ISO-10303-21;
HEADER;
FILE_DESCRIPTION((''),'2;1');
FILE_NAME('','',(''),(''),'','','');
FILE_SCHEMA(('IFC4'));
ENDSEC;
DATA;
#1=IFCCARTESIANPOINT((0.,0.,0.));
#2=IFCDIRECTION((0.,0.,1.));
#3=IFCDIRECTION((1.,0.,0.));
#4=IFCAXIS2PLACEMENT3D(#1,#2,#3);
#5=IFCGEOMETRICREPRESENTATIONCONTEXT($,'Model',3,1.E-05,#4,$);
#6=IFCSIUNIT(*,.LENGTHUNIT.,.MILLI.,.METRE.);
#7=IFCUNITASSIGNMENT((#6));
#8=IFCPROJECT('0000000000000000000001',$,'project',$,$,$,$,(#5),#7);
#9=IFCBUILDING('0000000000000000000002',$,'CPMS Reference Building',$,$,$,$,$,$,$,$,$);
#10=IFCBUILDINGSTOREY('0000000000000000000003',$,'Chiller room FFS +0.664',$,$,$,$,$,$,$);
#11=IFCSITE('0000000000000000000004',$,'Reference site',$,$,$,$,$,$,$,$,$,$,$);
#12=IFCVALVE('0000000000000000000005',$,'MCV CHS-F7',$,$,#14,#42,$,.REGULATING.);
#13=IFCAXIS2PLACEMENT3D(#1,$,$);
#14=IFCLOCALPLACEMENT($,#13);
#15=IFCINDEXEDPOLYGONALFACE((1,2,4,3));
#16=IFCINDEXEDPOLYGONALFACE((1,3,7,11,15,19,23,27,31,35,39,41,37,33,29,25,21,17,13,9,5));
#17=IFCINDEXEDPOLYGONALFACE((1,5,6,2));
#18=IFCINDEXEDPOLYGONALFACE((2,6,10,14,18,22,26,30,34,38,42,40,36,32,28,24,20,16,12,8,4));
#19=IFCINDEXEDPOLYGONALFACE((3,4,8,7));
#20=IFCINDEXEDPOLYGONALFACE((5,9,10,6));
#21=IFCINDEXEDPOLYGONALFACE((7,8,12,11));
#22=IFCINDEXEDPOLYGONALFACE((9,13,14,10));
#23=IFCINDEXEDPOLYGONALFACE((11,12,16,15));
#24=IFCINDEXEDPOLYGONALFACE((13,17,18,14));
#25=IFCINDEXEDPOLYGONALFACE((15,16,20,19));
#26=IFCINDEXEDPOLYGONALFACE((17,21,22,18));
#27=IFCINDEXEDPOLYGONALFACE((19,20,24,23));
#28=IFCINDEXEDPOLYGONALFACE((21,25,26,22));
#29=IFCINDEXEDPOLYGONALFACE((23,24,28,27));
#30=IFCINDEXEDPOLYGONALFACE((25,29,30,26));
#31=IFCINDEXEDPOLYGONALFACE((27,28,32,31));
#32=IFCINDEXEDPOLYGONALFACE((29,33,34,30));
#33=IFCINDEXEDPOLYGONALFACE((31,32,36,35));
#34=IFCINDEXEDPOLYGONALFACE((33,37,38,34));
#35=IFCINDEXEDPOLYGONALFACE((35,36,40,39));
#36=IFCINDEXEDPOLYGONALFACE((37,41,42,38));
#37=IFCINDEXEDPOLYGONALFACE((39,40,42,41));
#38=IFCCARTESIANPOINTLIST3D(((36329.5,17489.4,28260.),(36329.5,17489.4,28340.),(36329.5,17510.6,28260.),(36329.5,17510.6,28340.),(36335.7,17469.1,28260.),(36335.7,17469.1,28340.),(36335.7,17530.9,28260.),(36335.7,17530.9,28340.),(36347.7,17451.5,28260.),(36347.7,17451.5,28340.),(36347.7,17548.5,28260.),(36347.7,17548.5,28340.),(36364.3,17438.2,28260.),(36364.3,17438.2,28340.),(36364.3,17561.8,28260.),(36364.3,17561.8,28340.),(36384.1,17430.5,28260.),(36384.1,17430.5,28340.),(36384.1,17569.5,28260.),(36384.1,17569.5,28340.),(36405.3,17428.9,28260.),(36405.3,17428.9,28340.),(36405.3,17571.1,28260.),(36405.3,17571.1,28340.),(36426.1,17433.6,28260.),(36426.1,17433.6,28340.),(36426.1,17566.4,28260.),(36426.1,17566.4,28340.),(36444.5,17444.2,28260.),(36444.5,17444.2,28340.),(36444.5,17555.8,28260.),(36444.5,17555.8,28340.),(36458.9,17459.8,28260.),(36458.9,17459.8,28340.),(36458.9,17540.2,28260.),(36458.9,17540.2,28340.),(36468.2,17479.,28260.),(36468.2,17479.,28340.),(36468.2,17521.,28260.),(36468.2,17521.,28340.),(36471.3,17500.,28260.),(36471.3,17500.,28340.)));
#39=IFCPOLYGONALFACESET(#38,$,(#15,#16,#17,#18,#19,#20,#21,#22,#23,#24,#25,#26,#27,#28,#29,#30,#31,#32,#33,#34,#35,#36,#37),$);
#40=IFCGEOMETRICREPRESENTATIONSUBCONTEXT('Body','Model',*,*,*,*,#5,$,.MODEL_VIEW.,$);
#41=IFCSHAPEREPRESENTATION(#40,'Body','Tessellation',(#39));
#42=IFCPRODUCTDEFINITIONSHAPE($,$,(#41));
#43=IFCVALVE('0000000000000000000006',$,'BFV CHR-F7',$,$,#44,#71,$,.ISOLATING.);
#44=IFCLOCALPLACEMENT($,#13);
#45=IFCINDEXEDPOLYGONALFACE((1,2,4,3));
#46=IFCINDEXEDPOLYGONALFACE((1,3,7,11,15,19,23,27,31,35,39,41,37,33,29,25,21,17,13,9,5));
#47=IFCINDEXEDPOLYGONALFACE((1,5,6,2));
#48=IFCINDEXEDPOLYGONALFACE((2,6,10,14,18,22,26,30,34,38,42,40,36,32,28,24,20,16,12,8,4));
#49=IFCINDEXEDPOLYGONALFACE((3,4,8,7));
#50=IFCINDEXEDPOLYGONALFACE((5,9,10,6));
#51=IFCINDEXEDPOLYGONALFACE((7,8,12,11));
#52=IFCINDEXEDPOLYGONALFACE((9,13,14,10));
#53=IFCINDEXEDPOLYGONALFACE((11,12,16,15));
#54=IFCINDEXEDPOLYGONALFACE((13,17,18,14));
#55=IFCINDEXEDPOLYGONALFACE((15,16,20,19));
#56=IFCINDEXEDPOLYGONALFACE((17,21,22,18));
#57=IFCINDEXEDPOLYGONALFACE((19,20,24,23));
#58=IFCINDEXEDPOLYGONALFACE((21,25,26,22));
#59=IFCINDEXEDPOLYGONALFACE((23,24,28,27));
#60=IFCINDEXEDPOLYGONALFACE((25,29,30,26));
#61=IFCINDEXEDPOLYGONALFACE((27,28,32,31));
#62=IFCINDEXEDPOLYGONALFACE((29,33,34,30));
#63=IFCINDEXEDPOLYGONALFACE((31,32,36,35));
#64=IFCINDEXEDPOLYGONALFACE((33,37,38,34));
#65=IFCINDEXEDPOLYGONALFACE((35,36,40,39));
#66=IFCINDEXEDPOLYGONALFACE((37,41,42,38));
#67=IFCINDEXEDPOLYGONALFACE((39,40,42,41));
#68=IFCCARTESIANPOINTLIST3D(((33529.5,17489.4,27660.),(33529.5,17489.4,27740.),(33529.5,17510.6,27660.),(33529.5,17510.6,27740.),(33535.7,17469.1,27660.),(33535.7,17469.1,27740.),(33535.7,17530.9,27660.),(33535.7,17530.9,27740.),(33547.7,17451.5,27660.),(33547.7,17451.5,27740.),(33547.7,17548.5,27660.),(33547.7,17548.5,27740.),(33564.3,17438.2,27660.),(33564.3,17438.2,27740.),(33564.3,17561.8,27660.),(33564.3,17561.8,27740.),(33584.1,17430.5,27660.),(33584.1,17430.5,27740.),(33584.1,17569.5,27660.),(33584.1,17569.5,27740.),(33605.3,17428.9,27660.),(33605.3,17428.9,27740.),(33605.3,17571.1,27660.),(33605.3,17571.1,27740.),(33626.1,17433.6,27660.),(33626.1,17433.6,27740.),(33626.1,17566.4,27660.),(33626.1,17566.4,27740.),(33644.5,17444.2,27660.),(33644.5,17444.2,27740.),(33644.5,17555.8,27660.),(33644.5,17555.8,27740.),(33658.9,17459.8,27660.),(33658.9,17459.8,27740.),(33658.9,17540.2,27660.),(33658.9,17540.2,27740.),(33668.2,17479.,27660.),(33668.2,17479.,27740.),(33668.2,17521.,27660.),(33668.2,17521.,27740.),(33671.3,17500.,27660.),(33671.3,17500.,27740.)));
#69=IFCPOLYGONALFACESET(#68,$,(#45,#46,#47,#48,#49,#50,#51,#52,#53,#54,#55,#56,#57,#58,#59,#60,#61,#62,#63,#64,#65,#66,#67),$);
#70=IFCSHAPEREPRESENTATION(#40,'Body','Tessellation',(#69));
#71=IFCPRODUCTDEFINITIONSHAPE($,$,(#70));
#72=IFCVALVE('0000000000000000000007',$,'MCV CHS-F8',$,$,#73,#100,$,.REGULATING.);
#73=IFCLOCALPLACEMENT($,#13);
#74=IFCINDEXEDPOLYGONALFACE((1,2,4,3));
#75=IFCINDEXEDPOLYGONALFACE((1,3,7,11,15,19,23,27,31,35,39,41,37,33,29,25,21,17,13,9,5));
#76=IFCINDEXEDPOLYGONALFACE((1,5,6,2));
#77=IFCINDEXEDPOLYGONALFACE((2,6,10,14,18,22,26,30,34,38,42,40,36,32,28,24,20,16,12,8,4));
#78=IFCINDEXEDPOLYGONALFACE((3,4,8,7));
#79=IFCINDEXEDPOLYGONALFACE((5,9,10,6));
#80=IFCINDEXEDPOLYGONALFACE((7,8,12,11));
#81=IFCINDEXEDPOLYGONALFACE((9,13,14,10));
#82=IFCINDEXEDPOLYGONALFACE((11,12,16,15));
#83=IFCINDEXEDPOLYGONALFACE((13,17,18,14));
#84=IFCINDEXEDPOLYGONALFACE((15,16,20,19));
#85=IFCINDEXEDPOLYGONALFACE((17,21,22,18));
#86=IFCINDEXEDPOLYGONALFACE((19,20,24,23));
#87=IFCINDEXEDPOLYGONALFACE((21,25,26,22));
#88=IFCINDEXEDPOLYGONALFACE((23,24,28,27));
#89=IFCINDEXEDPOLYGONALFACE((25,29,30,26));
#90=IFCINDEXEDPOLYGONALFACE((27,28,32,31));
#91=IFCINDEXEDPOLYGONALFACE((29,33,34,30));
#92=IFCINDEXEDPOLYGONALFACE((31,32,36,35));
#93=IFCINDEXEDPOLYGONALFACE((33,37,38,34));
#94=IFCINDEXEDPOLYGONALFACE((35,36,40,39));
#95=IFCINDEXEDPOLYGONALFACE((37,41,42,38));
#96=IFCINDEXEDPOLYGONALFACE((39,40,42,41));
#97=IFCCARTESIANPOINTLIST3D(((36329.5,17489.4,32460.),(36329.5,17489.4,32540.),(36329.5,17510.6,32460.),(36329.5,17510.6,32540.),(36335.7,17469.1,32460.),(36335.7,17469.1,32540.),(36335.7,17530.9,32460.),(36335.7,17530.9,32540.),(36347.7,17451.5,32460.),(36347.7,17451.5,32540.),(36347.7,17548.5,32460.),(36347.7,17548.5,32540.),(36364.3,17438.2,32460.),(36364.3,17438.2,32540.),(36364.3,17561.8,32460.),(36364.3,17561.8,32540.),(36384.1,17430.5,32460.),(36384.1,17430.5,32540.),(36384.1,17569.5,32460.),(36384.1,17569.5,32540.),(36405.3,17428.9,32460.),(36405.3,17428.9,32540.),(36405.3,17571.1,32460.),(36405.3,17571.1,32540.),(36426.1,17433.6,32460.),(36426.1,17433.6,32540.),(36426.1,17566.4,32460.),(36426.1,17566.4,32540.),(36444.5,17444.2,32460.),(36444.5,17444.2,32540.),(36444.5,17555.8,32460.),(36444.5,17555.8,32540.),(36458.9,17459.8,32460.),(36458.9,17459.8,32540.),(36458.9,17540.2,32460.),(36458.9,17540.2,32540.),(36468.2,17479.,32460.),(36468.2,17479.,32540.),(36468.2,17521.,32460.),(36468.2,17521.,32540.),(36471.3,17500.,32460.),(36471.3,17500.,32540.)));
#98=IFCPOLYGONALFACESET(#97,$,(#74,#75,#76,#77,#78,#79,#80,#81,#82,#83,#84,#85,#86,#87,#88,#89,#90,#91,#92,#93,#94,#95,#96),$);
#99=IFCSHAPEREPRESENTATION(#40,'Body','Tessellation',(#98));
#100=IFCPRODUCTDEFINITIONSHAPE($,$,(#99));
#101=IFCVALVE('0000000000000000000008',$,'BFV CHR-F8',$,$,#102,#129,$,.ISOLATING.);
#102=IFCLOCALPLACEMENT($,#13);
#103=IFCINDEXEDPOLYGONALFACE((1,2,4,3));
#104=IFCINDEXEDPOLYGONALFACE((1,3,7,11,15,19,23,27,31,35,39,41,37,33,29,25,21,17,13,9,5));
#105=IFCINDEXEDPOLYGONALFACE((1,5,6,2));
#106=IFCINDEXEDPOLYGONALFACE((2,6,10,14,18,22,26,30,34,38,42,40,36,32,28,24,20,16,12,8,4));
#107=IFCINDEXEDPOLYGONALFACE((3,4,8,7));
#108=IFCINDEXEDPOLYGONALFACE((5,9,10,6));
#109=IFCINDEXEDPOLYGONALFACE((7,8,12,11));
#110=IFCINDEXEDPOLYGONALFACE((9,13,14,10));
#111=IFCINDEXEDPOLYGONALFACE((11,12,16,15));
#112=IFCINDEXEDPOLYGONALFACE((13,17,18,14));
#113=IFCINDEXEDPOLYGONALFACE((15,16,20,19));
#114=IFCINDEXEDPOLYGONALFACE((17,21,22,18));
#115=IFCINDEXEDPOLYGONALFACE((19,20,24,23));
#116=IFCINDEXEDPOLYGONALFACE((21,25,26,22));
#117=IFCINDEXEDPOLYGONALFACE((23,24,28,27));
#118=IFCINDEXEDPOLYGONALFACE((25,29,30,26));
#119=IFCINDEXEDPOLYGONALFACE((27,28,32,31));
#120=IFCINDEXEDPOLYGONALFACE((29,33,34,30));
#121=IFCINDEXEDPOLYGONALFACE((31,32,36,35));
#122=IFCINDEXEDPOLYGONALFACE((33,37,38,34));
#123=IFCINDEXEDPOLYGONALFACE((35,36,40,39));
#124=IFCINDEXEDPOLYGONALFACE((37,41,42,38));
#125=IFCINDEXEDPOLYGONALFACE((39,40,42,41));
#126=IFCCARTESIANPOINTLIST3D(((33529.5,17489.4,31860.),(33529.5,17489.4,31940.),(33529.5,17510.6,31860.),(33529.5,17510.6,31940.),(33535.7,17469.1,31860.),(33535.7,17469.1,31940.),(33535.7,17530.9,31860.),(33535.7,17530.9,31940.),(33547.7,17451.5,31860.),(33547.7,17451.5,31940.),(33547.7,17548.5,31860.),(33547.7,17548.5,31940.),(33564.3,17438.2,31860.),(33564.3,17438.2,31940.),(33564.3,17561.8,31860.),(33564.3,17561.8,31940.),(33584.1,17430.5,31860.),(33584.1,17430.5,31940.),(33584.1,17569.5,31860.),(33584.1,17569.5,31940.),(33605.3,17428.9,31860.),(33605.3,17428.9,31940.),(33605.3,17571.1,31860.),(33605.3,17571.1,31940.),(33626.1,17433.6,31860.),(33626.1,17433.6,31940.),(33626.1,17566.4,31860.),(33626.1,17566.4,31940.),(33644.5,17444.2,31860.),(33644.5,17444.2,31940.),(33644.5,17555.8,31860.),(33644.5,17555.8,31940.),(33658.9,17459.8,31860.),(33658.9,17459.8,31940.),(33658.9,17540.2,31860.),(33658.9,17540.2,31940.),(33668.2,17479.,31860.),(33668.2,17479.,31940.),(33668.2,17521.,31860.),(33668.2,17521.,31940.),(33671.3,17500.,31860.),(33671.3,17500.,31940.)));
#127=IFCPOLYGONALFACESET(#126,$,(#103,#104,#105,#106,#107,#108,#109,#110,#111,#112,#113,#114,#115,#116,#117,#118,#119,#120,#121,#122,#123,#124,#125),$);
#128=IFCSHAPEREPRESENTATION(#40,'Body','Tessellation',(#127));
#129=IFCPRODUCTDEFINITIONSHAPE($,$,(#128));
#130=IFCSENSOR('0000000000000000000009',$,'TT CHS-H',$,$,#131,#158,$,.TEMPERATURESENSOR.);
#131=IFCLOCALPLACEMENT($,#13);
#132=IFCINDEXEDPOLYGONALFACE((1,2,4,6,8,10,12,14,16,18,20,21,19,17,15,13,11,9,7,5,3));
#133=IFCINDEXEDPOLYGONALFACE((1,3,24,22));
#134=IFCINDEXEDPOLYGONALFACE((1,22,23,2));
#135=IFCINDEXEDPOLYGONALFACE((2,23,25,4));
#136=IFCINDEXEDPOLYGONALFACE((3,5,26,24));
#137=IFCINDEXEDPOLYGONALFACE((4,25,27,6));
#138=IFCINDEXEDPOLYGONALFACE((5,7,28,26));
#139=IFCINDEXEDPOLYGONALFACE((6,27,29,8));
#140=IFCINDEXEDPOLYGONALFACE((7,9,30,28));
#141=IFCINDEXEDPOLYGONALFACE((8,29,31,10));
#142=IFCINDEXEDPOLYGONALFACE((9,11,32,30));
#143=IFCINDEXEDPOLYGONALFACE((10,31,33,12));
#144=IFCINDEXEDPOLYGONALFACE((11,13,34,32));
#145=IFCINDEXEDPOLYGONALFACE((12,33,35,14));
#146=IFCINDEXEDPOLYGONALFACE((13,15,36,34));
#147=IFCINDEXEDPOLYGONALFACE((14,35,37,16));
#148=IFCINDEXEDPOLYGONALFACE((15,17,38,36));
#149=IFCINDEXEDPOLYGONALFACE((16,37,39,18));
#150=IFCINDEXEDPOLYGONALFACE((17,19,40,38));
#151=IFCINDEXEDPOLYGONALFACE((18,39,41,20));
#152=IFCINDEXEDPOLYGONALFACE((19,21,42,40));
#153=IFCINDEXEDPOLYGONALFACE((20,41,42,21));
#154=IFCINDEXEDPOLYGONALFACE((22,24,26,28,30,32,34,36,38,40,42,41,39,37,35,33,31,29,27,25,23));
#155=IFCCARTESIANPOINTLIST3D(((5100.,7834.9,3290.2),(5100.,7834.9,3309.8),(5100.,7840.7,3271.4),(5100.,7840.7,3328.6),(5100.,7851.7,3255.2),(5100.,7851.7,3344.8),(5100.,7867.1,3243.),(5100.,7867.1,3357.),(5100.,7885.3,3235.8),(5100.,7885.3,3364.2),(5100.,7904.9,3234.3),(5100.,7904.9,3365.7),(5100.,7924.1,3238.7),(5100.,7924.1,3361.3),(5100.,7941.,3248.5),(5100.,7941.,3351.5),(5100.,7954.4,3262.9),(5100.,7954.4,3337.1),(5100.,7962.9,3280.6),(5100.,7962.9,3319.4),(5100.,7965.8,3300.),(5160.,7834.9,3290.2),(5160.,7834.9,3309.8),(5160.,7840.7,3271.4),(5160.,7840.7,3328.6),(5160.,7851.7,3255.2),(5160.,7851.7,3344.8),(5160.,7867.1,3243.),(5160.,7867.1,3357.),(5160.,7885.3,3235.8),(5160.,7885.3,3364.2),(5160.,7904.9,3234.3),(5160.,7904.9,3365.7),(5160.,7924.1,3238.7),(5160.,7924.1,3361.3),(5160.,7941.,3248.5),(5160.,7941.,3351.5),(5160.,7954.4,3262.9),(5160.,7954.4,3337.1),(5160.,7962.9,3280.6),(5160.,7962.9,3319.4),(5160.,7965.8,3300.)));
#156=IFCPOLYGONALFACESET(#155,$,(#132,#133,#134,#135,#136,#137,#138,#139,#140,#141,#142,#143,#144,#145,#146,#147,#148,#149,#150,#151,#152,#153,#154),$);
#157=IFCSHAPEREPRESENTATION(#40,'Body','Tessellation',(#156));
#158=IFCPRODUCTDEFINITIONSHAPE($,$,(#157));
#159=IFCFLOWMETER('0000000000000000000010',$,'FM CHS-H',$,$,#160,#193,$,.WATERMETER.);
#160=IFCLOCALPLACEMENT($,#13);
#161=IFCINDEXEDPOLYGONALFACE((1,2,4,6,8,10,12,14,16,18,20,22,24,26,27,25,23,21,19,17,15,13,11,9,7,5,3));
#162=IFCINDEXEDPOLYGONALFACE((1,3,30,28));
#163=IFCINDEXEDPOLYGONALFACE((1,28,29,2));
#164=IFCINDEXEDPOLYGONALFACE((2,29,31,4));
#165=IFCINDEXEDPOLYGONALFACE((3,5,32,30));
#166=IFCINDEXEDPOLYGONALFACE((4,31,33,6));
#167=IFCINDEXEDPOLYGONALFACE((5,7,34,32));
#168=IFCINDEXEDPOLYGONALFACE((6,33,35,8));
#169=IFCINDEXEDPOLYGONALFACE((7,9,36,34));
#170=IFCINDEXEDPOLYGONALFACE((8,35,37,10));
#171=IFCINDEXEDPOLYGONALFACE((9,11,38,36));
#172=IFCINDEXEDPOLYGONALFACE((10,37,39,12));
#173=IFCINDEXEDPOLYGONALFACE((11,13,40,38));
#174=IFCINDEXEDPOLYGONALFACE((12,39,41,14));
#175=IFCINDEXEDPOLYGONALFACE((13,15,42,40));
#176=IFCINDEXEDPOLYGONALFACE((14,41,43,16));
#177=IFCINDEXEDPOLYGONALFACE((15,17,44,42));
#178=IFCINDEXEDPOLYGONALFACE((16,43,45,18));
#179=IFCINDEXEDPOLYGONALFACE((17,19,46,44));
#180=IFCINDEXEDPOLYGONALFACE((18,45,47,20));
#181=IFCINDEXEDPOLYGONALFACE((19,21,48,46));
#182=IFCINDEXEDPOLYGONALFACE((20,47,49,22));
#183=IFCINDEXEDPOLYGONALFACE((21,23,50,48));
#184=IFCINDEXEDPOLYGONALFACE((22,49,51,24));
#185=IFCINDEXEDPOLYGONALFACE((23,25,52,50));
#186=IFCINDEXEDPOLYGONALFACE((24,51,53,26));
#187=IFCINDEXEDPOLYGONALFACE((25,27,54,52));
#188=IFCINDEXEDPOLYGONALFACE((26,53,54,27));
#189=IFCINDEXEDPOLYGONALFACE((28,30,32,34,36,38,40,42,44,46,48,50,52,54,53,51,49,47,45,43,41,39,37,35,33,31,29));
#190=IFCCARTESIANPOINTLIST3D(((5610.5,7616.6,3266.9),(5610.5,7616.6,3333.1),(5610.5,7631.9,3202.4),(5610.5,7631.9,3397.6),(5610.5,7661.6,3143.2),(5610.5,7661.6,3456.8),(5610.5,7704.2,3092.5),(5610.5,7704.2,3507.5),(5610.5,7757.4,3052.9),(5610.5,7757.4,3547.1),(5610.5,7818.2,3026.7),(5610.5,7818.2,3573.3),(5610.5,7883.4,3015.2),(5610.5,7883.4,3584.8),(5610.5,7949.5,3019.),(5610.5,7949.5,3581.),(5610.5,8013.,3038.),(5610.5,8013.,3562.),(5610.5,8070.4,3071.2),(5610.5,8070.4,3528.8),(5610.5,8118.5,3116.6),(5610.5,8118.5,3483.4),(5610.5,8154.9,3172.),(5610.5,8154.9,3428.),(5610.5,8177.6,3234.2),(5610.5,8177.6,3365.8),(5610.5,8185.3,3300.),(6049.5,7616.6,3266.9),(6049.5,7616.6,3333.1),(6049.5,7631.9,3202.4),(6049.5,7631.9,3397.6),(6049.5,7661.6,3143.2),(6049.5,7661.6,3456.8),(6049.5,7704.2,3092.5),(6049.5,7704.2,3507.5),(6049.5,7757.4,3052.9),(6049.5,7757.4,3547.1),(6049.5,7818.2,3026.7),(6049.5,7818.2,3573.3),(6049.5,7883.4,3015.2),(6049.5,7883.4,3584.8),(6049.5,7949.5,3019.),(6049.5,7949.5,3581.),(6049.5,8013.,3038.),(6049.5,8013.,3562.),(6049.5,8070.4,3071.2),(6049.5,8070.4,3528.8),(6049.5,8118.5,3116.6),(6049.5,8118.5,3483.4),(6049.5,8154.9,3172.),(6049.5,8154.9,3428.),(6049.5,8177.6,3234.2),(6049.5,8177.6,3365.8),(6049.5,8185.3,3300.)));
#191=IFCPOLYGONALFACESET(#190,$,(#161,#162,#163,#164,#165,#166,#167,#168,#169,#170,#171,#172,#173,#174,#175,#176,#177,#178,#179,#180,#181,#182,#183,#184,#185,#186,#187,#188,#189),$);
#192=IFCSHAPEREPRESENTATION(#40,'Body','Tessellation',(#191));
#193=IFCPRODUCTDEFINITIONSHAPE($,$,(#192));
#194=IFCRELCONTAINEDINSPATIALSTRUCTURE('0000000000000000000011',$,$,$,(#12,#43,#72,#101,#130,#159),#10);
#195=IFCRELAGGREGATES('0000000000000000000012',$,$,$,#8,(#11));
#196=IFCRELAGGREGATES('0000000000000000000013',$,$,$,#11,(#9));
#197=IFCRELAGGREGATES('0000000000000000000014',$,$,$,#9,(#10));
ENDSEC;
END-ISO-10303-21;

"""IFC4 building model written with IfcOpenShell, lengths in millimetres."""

from ifc_helpers import new_model, si_unit, frame, origin_with_axes, origin_2d, place, context, subcontext, project, spatial, circle_curve, outline, extrude, element, save


model = new_model("IFC4")

# Units and contexts
model_context = context("Model", 3, precision=1e-05, world=origin_with_axes())
body_context = subcontext(model_context, "Body", "Model", "MODEL_VIEW")
ifc_project = project(units=[si_unit("LENGTHUNIT", "METRE", prefix="MILLI")], contexts=[model_context])

# Site, building, storey
site = spatial("IfcSite", under=ifc_project, Name="Reference site")
building = spatial("IfcBuilding", under=site, Name="CPMS Reference Building")
storey = spatial("IfcBuildingStorey", under=building, Name="Chiller room FFS +0.664")

# Valves
valve_1_placement = place(None, origin_with_axes())
element("IfcValve", 1, at=valve_1_placement, inside=storey, Name="MCV CHS-F7", PredefinedType="REGULATING", context=body_context, shape_type="SweptSolid", body=[
    extrude(outline(circle_curve(origin_2d(), 71.3)), frame((36400.0, 17500.0, 28340.0), z_axis=(0.0, 0.0, -1.0), x_axis=(1.0, 0.0, 0.0)), (0.0, 0.0, 1.0), 80.0),
])
valve_2_placement = place(None, origin_with_axes())
element("IfcValve", 2, at=valve_2_placement, inside=storey, Name="BFV CHR-F7", PredefinedType="ISOLATING", context=body_context, shape_type="SweptSolid", body=[
    extrude(outline(circle_curve(origin_2d(), 71.3)), frame((33600.0, 17500.0, 27660.0), z_axis=(0.0, 0.0, 1.0), x_axis=(1.0, 0.0, 0.0)), (0.0, 0.0, 1.0), 80.0),
])
valve_3_placement = place(None, origin_with_axes())
element("IfcValve", 3, at=valve_3_placement, inside=storey, Name="MCV CHS-F8", PredefinedType="REGULATING", context=body_context, shape_type="SweptSolid", body=[
    extrude(outline(circle_curve(origin_2d(), 71.3)), frame((36400.0, 17500.0, 32540.0), z_axis=(0.0, 0.0, -1.0), x_axis=(1.0, 0.0, 0.0)), (0.0, 0.0, 1.0), 80.0),
])
valve_4_placement = place(None, origin_with_axes())
element("IfcValve", 4, at=valve_4_placement, inside=storey, Name="BFV CHR-F8", PredefinedType="ISOLATING", context=body_context, shape_type="SweptSolid", body=[
    extrude(outline(circle_curve(origin_2d(), 71.3)), frame((33600.0, 17500.0, 31860.0), z_axis=(0.0, 0.0, 1.0), x_axis=(1.0, 0.0, 0.0)), (0.0, 0.0, 1.0), 80.0),
])

# Sensor
sensor_1_placement = place(None, origin_with_axes())
element("IfcSensor", 5, at=sensor_1_placement, inside=storey, Name="TT CHS-H", PredefinedType="TEMPERATURESENSOR", context=body_context, shape_type="SweptSolid", body=[
    extrude(outline(circle_curve(origin_2d(), 65.8)), frame((5100.0, 7900.0, 3300.0), z_axis=(1.0, 0.0, 0.0), x_axis=(0.0, 1.0, 0.0)), (0.0, 0.0, 1.0), 60.0),
])

# Flow meter
flow_meter_1_placement = place(None, origin_with_axes())
element("IfcFlowMeter", 6, at=flow_meter_1_placement, inside=storey, Name="FM CHS-H", PredefinedType="WATERMETER", context=body_context, shape_type="SweptSolid", body=[
    extrude(outline(circle_curve(origin_2d(), 285.3)), frame((5610.5, 7900.0, 3300.0), z_axis=(1.0, 0.0, 0.0), x_axis=(0.0, 1.0, 0.0)), (0.0, 0.0, 1.0), 438.9),
])

save(model, "model.ifc")
